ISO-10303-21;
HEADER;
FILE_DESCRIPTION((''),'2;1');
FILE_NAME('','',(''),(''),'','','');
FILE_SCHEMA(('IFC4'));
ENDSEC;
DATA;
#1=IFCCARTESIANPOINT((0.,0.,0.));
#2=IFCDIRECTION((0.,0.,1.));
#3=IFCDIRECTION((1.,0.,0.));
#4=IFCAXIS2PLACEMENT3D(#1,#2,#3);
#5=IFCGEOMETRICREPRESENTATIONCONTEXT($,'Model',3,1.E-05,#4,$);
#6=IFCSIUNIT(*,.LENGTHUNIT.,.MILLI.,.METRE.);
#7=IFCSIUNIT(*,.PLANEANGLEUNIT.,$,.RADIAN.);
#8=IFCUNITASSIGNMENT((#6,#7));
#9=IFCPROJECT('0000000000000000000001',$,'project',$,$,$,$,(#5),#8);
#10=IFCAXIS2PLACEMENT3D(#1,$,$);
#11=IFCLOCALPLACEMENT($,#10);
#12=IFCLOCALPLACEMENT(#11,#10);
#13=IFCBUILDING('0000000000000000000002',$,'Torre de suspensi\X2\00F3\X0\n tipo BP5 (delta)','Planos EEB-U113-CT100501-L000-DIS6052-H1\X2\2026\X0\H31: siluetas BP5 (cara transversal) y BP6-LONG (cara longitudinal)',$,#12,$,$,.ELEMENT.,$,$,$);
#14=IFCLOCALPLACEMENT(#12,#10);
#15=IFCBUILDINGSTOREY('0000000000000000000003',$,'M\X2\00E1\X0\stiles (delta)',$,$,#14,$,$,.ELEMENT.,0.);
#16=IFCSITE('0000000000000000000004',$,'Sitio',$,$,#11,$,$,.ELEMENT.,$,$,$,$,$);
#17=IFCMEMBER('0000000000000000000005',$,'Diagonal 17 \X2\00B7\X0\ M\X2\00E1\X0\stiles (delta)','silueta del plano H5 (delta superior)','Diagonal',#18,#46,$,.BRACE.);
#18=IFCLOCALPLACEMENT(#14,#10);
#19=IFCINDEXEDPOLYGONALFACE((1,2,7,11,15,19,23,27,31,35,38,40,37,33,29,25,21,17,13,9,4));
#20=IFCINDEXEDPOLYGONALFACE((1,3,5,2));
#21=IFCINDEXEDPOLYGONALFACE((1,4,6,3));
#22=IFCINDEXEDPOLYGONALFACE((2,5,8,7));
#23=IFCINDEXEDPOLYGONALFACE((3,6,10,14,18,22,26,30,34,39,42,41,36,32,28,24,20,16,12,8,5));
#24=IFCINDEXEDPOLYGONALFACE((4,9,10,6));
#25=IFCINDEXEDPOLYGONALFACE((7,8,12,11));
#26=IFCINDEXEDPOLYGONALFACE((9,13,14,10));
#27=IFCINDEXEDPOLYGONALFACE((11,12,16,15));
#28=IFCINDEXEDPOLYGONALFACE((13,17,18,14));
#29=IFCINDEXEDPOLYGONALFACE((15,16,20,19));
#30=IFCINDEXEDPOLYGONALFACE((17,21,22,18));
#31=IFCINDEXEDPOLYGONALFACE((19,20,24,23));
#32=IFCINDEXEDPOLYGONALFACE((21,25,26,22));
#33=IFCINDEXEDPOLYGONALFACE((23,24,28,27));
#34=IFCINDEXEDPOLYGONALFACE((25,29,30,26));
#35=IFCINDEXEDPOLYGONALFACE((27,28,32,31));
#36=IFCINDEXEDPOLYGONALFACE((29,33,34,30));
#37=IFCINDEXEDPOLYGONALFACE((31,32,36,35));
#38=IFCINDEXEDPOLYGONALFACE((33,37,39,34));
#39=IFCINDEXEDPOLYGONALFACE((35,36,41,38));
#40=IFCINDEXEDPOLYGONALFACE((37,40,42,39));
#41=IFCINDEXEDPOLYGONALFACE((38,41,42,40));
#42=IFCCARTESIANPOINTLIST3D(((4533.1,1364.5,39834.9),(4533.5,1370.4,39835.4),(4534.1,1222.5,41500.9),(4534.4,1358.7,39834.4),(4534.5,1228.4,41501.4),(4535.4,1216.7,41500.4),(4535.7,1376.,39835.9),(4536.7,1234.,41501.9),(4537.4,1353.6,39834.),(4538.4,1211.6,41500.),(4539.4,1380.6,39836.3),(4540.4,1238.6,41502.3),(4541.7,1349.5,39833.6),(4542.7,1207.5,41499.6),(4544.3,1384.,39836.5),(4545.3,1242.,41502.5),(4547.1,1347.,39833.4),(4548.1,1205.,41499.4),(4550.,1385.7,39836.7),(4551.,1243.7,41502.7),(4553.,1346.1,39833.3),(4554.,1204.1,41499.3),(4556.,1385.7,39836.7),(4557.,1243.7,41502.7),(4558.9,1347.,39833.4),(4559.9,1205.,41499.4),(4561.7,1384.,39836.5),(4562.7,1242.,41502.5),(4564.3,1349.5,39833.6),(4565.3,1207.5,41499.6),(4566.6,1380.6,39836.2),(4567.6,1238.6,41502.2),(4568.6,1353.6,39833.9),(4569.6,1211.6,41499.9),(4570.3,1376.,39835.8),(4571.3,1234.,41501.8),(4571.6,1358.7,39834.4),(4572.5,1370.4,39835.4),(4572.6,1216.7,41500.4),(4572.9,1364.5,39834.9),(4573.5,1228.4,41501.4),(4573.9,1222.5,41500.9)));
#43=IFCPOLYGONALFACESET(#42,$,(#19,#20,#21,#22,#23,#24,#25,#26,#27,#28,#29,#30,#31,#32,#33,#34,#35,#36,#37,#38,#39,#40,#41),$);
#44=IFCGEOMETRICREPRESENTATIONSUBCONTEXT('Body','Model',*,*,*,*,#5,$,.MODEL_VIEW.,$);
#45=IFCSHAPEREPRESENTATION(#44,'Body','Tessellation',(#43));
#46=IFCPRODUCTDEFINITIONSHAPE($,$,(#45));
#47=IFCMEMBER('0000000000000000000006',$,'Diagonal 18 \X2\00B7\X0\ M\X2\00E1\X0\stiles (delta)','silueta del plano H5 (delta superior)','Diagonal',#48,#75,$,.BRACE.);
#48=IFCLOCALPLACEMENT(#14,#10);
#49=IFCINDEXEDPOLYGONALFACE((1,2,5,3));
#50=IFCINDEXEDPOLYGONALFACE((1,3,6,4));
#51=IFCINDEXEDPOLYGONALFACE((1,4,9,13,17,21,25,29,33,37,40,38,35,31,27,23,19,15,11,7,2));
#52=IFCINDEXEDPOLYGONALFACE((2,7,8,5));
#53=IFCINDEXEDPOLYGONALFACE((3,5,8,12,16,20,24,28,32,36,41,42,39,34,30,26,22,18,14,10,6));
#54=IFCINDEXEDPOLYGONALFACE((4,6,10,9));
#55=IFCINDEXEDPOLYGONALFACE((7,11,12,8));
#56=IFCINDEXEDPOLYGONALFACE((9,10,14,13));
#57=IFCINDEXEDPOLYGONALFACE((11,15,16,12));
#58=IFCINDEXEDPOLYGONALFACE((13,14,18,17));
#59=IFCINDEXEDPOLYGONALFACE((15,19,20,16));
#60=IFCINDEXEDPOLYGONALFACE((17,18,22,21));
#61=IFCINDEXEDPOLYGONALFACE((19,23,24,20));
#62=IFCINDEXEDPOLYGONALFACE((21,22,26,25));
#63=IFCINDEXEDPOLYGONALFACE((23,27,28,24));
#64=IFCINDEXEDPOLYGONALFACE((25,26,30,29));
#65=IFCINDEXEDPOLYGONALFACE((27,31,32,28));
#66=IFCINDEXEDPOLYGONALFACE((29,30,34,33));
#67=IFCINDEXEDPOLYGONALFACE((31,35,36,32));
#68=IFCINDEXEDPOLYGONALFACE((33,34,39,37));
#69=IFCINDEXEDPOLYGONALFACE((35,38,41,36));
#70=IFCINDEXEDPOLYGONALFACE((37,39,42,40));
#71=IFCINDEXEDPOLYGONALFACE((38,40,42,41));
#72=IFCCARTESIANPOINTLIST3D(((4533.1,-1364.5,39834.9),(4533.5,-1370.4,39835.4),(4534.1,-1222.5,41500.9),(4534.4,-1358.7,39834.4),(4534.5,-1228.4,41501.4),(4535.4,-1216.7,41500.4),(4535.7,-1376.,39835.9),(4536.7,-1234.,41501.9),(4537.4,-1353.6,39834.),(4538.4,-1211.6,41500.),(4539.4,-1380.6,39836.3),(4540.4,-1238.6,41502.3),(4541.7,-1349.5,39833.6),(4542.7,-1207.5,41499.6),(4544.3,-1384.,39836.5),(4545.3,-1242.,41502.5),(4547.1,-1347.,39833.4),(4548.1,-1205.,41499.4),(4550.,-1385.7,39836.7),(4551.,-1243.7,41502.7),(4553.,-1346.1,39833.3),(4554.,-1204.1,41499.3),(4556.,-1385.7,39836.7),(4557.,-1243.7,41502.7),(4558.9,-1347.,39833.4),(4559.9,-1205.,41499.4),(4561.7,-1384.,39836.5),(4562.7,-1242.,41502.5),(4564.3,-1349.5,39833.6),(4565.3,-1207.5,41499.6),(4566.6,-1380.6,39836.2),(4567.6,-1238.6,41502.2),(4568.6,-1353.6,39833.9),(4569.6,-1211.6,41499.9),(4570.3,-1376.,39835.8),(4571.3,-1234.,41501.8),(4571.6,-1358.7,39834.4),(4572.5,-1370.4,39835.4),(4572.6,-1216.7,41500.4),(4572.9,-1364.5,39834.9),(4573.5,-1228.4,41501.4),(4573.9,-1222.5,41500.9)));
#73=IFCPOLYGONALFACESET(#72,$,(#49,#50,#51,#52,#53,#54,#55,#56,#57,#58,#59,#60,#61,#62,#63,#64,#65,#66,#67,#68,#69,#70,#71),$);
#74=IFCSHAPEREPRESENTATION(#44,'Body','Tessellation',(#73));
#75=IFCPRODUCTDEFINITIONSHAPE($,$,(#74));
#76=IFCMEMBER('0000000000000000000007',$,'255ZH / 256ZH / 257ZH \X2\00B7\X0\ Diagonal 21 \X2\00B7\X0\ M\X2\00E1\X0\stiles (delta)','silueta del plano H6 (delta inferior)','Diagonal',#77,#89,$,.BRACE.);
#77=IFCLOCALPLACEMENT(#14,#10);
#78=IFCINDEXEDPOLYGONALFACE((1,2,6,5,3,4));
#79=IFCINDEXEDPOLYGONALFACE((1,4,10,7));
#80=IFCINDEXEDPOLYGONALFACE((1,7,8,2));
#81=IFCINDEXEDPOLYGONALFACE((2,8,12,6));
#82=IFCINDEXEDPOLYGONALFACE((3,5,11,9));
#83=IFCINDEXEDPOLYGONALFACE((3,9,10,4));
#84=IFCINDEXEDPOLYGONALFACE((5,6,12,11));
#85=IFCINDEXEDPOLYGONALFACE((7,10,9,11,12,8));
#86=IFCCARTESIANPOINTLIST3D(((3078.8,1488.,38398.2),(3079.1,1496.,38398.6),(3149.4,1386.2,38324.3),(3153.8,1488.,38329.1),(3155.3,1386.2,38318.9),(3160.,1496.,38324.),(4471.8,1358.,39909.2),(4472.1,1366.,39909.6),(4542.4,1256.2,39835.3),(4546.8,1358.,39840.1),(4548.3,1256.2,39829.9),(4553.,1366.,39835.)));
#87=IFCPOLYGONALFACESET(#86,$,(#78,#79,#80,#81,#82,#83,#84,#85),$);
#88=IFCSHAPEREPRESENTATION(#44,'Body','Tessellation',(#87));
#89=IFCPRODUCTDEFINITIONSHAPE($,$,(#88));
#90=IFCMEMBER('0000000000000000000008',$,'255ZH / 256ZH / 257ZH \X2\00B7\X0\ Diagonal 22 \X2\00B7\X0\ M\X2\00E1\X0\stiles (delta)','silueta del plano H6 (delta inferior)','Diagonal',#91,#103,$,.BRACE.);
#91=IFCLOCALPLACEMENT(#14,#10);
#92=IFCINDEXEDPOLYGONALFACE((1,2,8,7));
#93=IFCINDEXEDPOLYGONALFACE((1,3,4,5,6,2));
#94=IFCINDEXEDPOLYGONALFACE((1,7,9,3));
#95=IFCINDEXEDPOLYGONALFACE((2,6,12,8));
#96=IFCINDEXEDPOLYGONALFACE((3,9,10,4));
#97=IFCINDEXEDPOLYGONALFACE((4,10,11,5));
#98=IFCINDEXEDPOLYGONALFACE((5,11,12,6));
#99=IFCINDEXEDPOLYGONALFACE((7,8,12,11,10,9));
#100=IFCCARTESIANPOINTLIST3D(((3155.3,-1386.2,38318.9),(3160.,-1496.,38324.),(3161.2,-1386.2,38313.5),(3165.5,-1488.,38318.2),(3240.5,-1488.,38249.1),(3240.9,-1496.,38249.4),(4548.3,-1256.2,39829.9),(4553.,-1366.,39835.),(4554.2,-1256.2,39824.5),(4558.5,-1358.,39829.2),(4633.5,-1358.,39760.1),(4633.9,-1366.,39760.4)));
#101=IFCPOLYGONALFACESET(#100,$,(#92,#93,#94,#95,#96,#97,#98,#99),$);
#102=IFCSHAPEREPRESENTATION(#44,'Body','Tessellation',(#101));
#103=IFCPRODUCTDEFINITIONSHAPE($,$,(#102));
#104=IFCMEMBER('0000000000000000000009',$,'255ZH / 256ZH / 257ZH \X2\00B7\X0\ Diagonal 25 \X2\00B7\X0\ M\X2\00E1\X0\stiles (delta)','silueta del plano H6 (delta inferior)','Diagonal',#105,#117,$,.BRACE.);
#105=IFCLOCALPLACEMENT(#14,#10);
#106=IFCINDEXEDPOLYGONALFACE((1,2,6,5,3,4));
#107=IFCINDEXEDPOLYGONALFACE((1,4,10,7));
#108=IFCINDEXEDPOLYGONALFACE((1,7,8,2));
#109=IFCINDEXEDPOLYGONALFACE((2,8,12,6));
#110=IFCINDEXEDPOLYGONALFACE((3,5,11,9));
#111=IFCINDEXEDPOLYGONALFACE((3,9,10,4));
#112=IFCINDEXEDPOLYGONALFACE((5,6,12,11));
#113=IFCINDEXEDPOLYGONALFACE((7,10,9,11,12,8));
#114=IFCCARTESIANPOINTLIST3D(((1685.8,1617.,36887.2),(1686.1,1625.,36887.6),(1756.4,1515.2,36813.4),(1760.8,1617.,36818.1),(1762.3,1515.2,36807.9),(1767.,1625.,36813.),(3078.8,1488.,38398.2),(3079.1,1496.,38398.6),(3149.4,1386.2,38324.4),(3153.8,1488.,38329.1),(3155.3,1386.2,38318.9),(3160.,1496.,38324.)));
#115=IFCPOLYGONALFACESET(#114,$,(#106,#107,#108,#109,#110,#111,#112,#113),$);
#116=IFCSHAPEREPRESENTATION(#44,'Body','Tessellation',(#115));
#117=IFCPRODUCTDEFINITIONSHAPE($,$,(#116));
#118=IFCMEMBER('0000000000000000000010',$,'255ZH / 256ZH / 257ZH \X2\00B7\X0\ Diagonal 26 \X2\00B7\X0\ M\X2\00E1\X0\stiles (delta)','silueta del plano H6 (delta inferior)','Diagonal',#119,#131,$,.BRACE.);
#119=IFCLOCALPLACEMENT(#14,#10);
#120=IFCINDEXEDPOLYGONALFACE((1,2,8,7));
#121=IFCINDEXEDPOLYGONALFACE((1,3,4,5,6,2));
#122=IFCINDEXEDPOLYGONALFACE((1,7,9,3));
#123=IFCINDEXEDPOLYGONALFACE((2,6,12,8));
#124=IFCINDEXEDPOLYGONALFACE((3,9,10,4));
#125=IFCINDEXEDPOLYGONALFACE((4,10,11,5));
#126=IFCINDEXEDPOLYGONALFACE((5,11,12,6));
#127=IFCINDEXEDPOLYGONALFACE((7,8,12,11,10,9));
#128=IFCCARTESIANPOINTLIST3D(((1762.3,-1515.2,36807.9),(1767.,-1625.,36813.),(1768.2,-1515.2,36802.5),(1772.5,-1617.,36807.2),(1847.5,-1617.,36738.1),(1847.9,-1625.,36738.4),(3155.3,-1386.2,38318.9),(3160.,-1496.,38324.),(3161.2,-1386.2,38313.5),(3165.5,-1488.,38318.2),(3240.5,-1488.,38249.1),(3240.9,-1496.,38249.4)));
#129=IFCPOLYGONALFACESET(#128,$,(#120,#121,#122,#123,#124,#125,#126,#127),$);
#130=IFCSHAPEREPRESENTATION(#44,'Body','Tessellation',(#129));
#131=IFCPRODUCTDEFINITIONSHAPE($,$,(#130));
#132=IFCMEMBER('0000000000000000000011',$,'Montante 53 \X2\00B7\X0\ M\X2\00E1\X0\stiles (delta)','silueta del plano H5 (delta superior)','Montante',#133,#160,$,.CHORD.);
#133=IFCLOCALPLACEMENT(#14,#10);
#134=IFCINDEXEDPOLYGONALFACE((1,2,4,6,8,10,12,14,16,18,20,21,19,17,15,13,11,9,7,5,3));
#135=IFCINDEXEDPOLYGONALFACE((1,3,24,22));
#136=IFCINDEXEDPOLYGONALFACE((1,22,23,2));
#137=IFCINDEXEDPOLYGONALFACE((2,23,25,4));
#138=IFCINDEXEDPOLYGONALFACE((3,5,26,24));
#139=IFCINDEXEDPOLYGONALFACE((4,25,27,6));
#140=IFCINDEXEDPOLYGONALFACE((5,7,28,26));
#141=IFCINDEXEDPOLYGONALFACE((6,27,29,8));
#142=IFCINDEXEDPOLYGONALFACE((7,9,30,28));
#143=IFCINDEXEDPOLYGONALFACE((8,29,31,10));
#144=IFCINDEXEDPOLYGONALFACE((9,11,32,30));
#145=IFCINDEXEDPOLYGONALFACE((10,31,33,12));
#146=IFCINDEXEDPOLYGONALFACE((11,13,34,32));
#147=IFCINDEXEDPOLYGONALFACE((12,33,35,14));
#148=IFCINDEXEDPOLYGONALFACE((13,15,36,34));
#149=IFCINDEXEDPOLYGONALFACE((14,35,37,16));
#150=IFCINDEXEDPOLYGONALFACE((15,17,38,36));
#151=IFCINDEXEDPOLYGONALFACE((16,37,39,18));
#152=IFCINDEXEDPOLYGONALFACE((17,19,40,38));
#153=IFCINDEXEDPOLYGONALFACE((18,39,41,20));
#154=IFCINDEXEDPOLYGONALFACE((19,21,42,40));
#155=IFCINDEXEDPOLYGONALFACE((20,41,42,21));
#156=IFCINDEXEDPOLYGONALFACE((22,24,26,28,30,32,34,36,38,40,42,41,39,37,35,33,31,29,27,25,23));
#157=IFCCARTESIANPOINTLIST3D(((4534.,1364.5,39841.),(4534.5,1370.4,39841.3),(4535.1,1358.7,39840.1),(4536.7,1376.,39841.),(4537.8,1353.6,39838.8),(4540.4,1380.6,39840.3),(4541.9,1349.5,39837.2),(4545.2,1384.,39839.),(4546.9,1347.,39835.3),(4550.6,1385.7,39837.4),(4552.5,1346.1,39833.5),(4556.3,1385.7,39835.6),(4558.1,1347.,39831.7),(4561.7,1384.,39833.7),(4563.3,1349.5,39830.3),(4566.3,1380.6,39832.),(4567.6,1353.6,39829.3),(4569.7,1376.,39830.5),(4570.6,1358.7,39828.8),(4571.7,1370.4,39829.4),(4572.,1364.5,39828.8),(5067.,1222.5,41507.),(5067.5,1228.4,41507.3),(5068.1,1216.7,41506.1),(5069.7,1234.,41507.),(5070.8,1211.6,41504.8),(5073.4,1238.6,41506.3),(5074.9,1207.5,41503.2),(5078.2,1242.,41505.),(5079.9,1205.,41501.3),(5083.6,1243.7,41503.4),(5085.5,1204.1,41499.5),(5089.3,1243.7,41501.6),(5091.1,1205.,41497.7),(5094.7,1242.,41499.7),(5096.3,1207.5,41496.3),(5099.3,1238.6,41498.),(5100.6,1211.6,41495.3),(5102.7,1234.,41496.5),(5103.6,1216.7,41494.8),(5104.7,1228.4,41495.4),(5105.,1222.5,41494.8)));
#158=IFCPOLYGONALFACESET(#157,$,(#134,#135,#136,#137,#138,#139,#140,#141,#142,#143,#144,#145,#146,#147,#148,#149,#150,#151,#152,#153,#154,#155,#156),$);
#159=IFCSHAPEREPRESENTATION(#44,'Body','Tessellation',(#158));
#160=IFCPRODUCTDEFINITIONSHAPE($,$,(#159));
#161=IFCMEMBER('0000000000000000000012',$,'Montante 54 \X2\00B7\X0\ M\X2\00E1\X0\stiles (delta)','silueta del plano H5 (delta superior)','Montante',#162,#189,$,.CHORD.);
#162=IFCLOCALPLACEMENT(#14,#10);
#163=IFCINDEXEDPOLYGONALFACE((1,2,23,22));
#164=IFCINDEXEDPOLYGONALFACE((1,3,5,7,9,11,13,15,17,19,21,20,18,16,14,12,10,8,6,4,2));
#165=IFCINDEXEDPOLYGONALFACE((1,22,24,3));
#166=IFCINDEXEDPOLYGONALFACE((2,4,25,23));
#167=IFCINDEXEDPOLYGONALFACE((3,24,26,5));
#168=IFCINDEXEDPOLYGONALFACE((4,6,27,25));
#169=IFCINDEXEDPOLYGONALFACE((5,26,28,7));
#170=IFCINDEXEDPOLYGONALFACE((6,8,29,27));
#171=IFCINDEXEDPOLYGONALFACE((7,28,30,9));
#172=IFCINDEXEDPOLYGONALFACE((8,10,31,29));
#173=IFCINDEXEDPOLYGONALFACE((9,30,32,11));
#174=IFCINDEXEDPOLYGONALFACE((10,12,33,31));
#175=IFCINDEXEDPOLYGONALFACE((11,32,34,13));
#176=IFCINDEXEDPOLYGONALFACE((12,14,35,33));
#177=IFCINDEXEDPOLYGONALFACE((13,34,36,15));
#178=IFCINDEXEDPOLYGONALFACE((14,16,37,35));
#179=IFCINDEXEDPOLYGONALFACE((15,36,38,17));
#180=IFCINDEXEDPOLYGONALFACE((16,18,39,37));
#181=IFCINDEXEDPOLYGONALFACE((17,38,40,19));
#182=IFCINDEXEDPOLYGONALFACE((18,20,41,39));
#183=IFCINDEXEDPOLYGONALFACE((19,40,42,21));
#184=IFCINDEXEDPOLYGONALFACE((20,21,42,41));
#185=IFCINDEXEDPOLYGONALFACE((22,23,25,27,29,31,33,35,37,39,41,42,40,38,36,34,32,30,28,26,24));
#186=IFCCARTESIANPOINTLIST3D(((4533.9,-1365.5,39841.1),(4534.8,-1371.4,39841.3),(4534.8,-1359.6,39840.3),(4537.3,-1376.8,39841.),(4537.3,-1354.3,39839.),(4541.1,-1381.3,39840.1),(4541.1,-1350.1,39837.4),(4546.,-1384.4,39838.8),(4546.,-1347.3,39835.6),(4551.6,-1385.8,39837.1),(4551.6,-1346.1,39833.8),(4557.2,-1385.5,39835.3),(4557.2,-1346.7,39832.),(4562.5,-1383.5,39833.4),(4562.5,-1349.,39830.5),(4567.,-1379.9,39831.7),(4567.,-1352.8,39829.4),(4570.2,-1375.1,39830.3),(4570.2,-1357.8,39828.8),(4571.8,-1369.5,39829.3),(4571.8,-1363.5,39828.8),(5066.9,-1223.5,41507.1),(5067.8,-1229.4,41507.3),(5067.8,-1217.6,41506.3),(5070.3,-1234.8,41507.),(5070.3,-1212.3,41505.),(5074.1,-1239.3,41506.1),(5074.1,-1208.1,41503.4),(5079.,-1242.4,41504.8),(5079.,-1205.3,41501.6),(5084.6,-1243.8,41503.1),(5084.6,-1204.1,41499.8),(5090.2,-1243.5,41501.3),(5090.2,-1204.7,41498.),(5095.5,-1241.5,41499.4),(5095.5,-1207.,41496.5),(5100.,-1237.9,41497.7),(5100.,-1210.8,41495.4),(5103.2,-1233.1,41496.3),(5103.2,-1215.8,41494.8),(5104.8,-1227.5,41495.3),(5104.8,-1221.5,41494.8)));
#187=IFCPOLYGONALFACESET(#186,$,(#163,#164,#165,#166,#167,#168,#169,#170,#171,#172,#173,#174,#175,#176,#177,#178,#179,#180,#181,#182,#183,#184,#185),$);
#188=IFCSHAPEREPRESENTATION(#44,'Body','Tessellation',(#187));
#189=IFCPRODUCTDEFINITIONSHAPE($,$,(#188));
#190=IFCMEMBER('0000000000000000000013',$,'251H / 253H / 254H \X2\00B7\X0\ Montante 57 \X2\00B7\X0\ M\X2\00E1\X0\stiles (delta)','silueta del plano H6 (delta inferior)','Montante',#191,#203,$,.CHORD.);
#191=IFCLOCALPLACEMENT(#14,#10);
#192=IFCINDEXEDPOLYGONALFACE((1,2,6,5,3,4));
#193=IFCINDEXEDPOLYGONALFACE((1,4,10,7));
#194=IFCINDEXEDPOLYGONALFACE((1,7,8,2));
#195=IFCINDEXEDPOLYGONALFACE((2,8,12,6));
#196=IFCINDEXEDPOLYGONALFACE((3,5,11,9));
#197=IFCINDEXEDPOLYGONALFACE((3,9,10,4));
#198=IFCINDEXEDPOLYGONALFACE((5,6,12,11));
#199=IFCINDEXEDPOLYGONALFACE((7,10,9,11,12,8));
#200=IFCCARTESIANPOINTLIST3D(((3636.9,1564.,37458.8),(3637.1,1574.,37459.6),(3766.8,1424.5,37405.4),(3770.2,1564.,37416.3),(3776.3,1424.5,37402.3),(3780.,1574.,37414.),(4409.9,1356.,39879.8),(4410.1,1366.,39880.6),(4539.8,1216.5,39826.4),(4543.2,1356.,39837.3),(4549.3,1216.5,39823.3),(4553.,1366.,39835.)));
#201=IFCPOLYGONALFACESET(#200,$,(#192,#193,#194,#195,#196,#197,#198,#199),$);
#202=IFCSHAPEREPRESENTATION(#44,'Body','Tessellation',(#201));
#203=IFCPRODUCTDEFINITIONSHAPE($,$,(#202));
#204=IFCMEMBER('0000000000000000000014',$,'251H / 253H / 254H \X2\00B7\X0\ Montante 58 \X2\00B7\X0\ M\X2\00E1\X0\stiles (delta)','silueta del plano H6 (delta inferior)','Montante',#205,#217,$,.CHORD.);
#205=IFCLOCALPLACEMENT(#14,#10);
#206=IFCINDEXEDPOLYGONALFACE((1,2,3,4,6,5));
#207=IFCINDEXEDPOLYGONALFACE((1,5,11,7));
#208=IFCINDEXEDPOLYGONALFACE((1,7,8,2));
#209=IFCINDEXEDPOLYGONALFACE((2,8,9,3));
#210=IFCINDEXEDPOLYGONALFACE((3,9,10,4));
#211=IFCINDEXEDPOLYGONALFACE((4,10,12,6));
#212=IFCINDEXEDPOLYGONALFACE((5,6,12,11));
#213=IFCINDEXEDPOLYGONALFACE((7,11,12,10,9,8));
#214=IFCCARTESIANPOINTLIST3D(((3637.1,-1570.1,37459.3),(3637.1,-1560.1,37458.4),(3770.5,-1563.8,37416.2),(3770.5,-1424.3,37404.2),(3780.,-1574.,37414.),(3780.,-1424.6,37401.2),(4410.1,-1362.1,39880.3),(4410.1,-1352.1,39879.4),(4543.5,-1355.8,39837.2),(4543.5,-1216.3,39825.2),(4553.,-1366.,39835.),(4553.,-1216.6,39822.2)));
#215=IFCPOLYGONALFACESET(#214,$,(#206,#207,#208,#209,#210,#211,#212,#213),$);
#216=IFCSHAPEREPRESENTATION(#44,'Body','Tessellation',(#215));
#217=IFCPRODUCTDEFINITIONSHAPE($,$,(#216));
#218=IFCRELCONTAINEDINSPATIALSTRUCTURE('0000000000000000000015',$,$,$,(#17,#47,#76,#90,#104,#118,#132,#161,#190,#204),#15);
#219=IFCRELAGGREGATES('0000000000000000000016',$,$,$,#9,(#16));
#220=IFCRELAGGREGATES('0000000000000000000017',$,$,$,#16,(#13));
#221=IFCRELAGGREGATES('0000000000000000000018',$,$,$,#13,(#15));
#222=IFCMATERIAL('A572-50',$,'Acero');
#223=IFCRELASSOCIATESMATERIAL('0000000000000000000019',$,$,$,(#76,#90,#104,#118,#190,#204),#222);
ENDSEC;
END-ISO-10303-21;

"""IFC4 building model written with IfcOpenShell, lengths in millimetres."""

from ifc_helpers import new_model, si_unit, frame, frame_2d, origin, origin_with_axes, place, context, subcontext, project, spatial, circle, l_section, extrude, material, element, save


model = new_model("IFC4")

# Units and contexts
model_context = context("Model", 3, precision=1e-05, world=origin_with_axes())
body_context = subcontext(model_context, "Body", "Model", "MODEL_VIEW")
ifc_project = project(units=[si_unit("LENGTHUNIT", "METRE", prefix="MILLI"), si_unit("PLANEANGLEUNIT", "RADIAN")], contexts=[model_context])

# Site, building, storey
site_placement = place(None, origin())
site = spatial("IfcSite", under=ifc_project, at=site_placement, Name="Sitio", CompositionType="ELEMENT")
building_placement = place(site_placement, origin())
building = spatial("IfcBuilding", under=site, at=building_placement, Name="Torre de suspensión tipo BP5 (delta)", Description="Planos EEB-U113-CT100501-L000-DIS6052-H1…H31: siluetas BP5 (cara transversal) y BP6-LONG (cara longitudinal)", CompositionType="ELEMENT")
storey_placement = place(building_placement, origin())
storey = spatial("IfcBuildingStorey", under=building, at=storey_placement, Name="Mástiles (delta)", CompositionType="ELEMENT", Elevation=0.0)

# Members
for number, where, z_axis, x_axis, name in (
    (1, (4554.0, 1224.0, 41501.0), (-0.000598, 0.084926, -0.996387), (-0.000051, -0.996387, -0.084926), "Diagonal 17 · Mástiles (delta)"),
    (2, (4554.0, -1224.0, 41501.0), (-0.000598, -0.084926, -0.996387), (-0.000051, 0.996387, -0.084926), "Diagonal 18 · Mástiles (delta)"),
):
    element("IfcMember", number, at=place(storey_placement, frame(where, z_axis=z_axis, x_axis=x_axis)), inside=storey, Name=name, Description="silueta del plano H5 (delta superior)", ObjectType="Diagonal", PredefinedType="BRACE", context=body_context, shape_type="SweptSolid", body=[
        extrude(circle(Radius=20.0), None, (0.0, 0.0, 1.0), 1672.0),
    ])
ifc_material = material(Name="A572-50", Category="Acero")
for number, where, z_axis, x_axis, name in (
    (3, (4553.0, 1366.0, 39835.0), (-0.676463, 0.06313, -0.733766), (-0.042791, -0.998005, -0.046415), "255ZH / 256ZH / 257ZH · Diagonal 21 · Mástiles (delta)"),
    (4, (4553.0, -1366.0, 39835.0), (-0.676463, -0.06313, -0.733766), (-0.042791, 0.998005, -0.046415), "255ZH / 256ZH / 257ZH · Diagonal 22 · Mástiles (delta)"),
):
    element("IfcMember", number, at=place(storey_placement, frame(where, z_axis=z_axis, x_axis=x_axis)), inside=storey, material=ifc_material, Name=name, Description="silueta del plano H6 (delta inferior)", ObjectType="Diagonal", PredefinedType="BRACE", context=body_context, shape_type="SweptSolid", body=[
        extrude(l_section(Depth=110.0, Width=110.0, Thickness=8.0, at=frame_2d((55.0, 55.0))), None, (0.0, 0.0, 1.0), 2059.2),
    ])
for number, where, z_axis, x_axis, name in (
    (5, (3160.0, 1496.0, 38324.0), (-0.676484, 0.062646, -0.733788), (-0.042463, -0.998036, -0.04606), "255ZH / 256ZH / 257ZH · Diagonal 25 · Mástiles (delta)"),
    (6, (3160.0, -1496.0, 38324.0), (-0.676484, -0.062646, -0.733788), (-0.042463, 0.998036, -0.04606), "255ZH / 256ZH / 257ZH · Diagonal 26 · Mástiles (delta)"),
):
    element("IfcMember", number, at=place(storey_placement, frame(where, z_axis=z_axis, x_axis=x_axis)), inside=storey, material=ifc_material, Name=name, Description="silueta del plano H6 (delta inferior)", ObjectType="Diagonal", PredefinedType="BRACE", context=body_context, shape_type="SweptSolid", body=[
        extrude(l_section(Depth=110.0, Width=110.0, Thickness=8.0, at=frame_2d((55.0, 55.0))), None, (0.0, 0.0, 1.0), 2059.2),
    ])
for number, where, z_axis, x_axis, name in (
    (7, (5086.0, 1224.0, 41501.0), (-0.303714, 0.080915, -0.949321), (-0.024656, -0.996721, -0.077067), "Montante 53 · Mástiles (delta)"),
    (8, (5086.0, -1224.0, 41501.0), (-0.303714, -0.080915, -0.949321), (-0.952763, 0.025793, 0.302617), "Montante 54 · Mástiles (delta)"),
):
    element("IfcMember", number, at=place(storey_placement, frame(where, z_axis=z_axis, x_axis=x_axis)), inside=storey, Name=name, Description="silueta del plano H5 (delta superior)", ObjectType="Montante", PredefinedType="CHORD", context=body_context, shape_type="SweptSolid", body=[
        extrude(circle(Radius=20.0), None, (0.0, 0.0, 1.0), 1754.9),
    ])
for number, where, z_axis, x_axis, name in (
    (9, (4553.0, 1366.0, 39835.0), (-0.303148, 0.081572, -0.949446), (-0.024811, -0.996667, -0.077707), "251H / 253H / 254H · Montante 57 · Mástiles (delta)"),
    (10, (4553.0, -1366.0, 39835.0), (-0.303148, -0.081572, -0.949446), (-0.952943, 0.025949, 0.302035), "251H / 253H / 254H · Montante 58 · Mástiles (delta)"),
):
    element("IfcMember", number, at=place(storey_placement, frame(where, z_axis=z_axis, x_axis=x_axis)), inside=storey, material=ifc_material, Name=name, Description="silueta del plano H6 (delta inferior)", ObjectType="Montante", PredefinedType="CHORD", context=body_context, shape_type="SweptSolid", body=[
        extrude(l_section(Depth=150.0, Width=150.0, Thickness=10.0, at=frame_2d((75.0, 75.0))), None, (0.0, 0.0, 1.0), 2549.9),
    ])

save(model, "model.ifc")
